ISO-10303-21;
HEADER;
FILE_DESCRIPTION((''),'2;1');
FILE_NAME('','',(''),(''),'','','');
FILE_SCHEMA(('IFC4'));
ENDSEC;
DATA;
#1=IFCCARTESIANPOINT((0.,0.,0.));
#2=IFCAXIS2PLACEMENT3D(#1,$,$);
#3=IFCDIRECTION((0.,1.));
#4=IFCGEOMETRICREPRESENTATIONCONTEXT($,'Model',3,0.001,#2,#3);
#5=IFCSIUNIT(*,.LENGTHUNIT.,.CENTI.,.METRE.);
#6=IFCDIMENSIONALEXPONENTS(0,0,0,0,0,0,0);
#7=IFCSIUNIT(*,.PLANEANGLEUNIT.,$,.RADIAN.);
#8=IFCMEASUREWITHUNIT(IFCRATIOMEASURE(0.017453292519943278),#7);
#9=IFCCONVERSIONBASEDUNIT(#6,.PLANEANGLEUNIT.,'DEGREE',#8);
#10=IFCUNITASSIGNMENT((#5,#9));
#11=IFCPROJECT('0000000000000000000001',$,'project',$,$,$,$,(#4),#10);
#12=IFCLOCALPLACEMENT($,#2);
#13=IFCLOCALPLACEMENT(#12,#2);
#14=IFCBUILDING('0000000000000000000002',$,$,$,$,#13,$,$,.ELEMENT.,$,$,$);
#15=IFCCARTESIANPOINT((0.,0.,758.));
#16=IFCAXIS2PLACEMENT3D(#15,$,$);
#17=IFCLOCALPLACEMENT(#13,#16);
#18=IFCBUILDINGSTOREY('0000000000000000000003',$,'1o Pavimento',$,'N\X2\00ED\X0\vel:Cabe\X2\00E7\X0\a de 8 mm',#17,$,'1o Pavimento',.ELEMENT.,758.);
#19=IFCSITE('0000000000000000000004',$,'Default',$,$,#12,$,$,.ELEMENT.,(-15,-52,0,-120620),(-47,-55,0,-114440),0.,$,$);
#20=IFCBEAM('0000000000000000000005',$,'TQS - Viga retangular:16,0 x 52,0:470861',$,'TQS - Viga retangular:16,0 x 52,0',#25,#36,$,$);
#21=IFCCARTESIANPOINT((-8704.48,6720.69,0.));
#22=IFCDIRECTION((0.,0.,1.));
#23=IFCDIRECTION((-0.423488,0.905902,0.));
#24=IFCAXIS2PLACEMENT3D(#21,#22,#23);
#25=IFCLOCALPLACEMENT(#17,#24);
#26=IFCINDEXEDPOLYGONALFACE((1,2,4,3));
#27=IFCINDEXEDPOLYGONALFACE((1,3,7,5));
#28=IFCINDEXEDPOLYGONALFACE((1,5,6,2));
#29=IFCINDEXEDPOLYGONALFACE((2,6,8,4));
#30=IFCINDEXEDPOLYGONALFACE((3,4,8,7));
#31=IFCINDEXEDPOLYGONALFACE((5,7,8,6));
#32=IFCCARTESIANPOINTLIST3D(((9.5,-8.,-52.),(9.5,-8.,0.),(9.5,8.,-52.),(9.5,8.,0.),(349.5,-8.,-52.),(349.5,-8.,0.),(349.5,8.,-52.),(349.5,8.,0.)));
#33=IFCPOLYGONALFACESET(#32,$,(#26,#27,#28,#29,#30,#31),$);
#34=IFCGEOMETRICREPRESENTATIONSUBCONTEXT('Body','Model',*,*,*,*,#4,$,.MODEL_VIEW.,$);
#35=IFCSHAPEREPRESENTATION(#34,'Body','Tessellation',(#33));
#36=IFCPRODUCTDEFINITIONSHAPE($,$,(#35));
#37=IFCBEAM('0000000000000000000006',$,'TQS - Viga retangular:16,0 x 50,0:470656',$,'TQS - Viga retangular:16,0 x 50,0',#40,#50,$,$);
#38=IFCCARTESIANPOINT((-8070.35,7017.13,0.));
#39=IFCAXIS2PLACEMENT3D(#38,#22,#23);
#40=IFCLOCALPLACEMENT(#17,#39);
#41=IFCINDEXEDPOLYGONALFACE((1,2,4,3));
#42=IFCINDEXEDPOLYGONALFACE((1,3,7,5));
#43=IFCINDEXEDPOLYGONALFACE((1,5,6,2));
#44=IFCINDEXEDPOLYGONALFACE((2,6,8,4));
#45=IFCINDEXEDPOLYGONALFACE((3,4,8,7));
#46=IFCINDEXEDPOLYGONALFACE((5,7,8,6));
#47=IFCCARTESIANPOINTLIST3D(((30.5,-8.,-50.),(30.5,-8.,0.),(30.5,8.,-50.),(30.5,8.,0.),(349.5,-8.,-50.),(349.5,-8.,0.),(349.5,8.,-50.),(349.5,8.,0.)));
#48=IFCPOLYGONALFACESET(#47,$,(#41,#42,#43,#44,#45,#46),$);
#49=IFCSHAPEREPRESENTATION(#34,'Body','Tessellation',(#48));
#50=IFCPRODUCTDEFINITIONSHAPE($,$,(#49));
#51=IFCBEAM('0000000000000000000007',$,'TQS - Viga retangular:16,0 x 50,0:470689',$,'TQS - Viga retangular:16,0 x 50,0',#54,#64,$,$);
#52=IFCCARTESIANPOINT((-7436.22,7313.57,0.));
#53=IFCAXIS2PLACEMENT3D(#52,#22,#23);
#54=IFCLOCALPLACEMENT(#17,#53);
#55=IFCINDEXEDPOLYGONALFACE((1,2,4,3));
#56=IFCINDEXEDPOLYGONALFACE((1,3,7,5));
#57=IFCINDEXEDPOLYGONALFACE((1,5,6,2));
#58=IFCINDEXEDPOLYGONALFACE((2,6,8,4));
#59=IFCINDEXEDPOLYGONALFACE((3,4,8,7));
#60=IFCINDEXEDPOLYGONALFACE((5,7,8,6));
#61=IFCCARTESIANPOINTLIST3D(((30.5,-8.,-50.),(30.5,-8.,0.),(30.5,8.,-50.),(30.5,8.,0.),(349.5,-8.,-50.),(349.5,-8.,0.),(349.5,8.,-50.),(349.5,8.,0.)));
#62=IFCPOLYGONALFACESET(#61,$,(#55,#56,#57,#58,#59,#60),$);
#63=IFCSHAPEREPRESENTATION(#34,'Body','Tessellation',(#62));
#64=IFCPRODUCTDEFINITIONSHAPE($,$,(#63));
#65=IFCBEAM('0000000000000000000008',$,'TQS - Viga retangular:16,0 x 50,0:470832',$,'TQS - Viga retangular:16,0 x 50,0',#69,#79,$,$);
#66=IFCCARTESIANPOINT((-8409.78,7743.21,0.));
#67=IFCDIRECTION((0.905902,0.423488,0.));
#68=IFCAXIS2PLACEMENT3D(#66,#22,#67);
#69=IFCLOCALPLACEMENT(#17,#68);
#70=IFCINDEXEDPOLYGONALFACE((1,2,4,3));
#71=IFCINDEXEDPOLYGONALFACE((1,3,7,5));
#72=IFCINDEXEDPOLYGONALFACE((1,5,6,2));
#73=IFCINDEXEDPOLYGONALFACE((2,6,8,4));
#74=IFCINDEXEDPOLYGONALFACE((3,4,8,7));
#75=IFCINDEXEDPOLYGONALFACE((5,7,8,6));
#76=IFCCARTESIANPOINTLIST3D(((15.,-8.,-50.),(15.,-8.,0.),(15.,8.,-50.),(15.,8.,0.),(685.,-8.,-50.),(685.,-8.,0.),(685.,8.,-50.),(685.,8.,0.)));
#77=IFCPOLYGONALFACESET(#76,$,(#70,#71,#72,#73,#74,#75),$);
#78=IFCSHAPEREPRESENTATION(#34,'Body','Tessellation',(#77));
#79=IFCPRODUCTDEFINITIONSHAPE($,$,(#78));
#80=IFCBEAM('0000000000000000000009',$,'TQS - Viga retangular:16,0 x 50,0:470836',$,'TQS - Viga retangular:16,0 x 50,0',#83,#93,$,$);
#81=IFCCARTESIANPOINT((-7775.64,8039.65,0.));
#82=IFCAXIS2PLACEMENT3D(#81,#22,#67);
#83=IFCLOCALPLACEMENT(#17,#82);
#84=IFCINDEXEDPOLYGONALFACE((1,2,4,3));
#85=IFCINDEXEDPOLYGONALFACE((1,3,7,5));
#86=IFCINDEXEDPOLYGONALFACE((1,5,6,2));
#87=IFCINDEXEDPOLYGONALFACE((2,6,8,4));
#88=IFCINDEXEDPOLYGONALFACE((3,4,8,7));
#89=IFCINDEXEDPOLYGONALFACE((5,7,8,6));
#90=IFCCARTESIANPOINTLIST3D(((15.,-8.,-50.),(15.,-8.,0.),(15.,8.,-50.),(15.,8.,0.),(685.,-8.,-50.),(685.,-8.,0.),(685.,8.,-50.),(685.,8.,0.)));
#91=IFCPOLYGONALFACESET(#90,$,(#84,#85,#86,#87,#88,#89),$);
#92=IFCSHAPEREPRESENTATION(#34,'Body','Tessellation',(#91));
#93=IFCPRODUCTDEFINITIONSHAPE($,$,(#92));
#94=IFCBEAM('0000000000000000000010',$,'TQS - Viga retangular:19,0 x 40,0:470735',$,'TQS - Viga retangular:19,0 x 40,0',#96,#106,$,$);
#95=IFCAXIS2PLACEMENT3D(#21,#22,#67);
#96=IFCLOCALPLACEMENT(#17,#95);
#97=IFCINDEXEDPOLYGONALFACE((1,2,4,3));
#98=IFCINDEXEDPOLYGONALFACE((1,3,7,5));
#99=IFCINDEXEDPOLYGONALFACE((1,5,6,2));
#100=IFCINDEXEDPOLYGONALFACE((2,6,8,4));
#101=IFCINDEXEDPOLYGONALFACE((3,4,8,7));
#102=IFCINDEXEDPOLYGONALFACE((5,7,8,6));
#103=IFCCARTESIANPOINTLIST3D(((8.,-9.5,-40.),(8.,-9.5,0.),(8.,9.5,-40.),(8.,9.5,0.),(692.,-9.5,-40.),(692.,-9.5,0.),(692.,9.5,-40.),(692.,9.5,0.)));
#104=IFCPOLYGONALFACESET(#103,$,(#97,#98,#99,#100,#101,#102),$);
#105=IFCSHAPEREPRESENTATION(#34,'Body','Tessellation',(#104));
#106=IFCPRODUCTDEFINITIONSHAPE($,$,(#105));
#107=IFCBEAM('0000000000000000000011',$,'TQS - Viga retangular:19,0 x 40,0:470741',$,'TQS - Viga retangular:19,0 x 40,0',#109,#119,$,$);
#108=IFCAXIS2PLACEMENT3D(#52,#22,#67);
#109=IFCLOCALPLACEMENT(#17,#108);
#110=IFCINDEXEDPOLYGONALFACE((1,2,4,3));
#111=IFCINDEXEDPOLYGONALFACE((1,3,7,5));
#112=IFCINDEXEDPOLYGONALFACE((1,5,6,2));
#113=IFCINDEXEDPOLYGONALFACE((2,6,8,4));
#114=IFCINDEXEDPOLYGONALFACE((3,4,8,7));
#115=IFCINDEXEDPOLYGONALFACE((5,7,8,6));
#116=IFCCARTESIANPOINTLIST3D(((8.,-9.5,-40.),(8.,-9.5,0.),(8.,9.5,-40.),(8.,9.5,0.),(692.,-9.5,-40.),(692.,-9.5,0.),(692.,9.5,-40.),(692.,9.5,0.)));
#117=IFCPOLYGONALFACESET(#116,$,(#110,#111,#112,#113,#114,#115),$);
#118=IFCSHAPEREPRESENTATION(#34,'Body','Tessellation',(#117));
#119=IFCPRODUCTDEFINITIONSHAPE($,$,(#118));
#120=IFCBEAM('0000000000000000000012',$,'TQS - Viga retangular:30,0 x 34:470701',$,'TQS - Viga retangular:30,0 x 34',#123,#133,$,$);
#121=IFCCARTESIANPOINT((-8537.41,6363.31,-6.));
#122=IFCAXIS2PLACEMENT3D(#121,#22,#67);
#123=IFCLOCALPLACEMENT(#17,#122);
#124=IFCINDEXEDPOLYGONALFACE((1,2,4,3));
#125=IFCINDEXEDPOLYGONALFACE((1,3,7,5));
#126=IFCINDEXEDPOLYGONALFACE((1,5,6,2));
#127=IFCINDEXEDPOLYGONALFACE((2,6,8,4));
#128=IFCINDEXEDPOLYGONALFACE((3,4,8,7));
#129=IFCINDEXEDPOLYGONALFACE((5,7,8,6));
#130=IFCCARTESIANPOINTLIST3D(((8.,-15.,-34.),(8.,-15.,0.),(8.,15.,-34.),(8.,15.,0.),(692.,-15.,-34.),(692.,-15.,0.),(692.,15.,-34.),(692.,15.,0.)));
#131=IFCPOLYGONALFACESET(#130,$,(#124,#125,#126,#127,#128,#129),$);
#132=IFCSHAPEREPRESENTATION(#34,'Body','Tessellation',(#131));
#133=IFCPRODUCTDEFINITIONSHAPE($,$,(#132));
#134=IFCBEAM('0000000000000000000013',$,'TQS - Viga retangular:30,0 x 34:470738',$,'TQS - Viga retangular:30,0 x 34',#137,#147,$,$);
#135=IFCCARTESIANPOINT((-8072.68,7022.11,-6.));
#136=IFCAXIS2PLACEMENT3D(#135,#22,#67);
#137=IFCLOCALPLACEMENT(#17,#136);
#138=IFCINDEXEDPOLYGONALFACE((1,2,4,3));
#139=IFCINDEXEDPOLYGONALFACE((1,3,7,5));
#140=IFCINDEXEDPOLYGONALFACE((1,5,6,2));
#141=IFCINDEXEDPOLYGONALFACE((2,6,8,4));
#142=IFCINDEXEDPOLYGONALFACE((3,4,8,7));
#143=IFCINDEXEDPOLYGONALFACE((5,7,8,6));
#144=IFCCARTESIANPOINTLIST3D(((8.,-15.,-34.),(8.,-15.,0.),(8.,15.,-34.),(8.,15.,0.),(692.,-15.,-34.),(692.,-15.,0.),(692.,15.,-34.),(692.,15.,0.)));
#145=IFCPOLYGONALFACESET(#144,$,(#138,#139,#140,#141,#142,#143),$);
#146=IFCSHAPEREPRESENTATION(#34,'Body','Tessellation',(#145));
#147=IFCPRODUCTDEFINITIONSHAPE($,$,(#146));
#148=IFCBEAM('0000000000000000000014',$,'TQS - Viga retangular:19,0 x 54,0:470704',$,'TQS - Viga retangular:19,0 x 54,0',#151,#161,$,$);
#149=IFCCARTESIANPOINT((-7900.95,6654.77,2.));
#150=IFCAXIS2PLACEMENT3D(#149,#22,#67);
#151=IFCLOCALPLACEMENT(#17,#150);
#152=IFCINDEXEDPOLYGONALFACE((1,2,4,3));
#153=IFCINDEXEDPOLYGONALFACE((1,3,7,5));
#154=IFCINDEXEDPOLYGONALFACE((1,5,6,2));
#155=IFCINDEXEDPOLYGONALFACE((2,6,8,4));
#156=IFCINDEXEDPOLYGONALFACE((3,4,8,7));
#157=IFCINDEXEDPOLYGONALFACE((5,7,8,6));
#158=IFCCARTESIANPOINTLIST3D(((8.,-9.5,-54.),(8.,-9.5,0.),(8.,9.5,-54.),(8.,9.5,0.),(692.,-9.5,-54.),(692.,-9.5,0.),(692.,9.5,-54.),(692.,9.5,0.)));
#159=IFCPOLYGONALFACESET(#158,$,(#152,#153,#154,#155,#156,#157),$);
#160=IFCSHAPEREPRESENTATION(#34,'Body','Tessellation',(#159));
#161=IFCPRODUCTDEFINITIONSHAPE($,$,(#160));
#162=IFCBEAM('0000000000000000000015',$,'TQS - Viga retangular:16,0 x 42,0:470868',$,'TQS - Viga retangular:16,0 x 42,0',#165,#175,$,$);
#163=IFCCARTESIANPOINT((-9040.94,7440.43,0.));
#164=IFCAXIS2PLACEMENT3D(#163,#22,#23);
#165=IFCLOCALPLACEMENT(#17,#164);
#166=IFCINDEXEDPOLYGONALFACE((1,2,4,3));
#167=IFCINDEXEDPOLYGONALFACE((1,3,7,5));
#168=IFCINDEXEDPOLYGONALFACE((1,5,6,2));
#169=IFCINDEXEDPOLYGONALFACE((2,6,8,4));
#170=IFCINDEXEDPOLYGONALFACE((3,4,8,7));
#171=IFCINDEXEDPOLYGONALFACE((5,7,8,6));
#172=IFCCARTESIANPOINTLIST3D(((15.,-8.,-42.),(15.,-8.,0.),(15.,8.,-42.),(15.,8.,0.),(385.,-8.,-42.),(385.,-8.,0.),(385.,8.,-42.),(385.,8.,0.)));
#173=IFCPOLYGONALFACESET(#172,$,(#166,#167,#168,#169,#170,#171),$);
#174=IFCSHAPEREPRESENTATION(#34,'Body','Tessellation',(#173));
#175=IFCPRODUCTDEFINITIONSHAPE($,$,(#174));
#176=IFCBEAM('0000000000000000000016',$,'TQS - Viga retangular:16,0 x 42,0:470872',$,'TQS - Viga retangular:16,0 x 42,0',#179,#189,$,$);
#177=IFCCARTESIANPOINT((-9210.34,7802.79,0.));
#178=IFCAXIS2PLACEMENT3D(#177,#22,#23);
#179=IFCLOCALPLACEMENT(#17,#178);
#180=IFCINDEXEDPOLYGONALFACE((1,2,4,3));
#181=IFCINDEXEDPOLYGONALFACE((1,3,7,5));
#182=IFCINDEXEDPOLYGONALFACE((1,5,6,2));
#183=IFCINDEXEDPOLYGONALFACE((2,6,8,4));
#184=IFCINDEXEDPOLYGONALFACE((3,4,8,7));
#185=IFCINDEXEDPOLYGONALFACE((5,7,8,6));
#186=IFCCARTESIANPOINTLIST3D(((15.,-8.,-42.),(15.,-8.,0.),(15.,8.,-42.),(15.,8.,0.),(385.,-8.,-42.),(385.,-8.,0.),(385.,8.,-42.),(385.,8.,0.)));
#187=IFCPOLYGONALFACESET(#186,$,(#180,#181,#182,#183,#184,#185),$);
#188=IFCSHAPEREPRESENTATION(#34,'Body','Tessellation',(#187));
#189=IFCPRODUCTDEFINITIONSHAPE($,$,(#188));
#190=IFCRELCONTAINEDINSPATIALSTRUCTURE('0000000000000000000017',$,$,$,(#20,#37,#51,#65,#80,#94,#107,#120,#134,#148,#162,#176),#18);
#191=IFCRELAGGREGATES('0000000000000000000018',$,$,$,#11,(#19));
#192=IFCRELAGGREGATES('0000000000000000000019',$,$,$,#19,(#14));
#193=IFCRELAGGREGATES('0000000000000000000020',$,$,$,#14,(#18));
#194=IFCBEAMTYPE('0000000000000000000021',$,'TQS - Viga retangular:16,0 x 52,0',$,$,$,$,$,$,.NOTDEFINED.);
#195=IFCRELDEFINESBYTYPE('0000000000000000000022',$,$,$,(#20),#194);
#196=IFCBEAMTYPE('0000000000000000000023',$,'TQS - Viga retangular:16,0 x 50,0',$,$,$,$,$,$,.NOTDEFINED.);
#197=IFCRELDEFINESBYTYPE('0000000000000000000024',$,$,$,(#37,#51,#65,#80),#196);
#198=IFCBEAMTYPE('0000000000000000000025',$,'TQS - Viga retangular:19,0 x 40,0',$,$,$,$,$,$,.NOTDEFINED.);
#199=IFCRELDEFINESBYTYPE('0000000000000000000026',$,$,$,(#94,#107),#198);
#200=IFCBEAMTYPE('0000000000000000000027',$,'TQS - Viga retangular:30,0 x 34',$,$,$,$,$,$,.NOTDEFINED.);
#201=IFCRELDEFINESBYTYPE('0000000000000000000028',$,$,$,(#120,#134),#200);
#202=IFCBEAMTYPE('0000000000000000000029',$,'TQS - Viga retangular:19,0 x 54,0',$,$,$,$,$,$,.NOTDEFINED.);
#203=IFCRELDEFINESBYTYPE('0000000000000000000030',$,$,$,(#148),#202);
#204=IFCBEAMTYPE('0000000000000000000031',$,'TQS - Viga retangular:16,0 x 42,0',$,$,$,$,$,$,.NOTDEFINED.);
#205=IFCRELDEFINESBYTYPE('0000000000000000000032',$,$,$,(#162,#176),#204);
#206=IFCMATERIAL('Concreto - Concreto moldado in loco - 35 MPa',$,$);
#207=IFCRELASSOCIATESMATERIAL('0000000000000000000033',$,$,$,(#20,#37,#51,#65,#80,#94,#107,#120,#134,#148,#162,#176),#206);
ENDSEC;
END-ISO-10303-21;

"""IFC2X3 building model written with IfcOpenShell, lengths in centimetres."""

from ifc_helpers import new_model, entity, si_unit, converted_unit, direction, frame, frame_2d, origin, origin_2d_with_axis, place, context, subcontext, project, spatial, rectangle, extrude, material, type_object, element, save


model = new_model("IFC2X3")

# Units and contexts
model_context = context("Model", 3, precision=0.001, world=origin(), true_north=direction((0.0, 1.0)))
body_context = subcontext(model_context, "Body", "Model", "MODEL_VIEW")
ifc_project = project(units=[si_unit("LENGTHUNIT", "METRE", prefix="CENTI"), converted_unit("PLANEANGLEUNIT", "DEGREE", entity("IfcRatioMeasure", 0.017453292519943278), si_unit("PLANEANGLEUNIT", "RADIAN"), dimensions=[0, 0, 0, 0, 0, 0, 0])], contexts=[model_context])

# Site, building, storey
site_placement = place(None, origin())
site = spatial("IfcSite", under=ifc_project, at=site_placement, Name="Default", CompositionType="ELEMENT", RefLatitude=(-15, -52, 0, -120620), RefLongitude=(-47, -55, 0, -114440), RefElevation=0.0)
building_placement = place(site_placement, origin())
building = spatial("IfcBuilding", under=site, at=building_placement, CompositionType="ELEMENT")
storey_placement = place(building_placement, frame((0.0, 0.0, 758.0)))
storey = spatial("IfcBuildingStorey", under=building, at=storey_placement, Name="1o Pavimento", ObjectType="Nível:Cabeça de 8 mm", LongName="1o Pavimento", CompositionType="ELEMENT", Elevation=758.0)

# Beams
ifc_material_1 = material(Name="Concreto - Concreto moldado in loco - 35 MPa")
beam_type_1 = type_object("IfcBeamType", Name="TQS - Viga retangular:16,0 x 52,0", PredefinedType="NOTDEFINED")
beam_1_placement = place(storey_placement, frame((-8704.48, 6720.69, 0.0), z_axis=(0.0, 0.0, 1.0), x_axis=(-0.423488, 0.905902, 0.0)))
element("IfcBeam", 1, at=beam_1_placement, inside=storey, type_object=beam_type_1, material=ifc_material_1, Name="TQS - Viga retangular:16,0 x 52,0:470861", ObjectType="TQS - Viga retangular:16,0 x 52,0", context=body_context, shape_type="SweptSolid", body=[
    extrude(rectangle(XDim=52.0, YDim=16.0, at=frame_2d((0.0, 0.0), x_axis=(1.0, 0.0))), frame((9.5, 0.0, -26.0), z_axis=(1.0, 0.0, 0.0), x_axis=(0.0, 0.0, -1.0)), (0.0, 0.0, 1.0), 340.0),
])
beam_type_2 = type_object("IfcBeamType", Name="TQS - Viga retangular:16,0 x 50,0", PredefinedType="NOTDEFINED")
beam_2_placement = place(storey_placement, frame((-8070.35, 7017.13, 0.0), z_axis=(0.0, 0.0, 1.0), x_axis=(-0.423488, 0.905902, 0.0)))
element("IfcBeam", 2, at=beam_2_placement, inside=storey, type_object=beam_type_2, material=ifc_material_1, Name="TQS - Viga retangular:16,0 x 50,0:470656", ObjectType="TQS - Viga retangular:16,0 x 50,0", context=body_context, shape_type="SweptSolid", body=[
    extrude(rectangle(XDim=50.0, YDim=16.0, at=frame_2d((0.0, 0.0), x_axis=(1.0, 0.0))), frame((30.5, 0.0, -25.0), z_axis=(1.0, 0.0, 0.0), x_axis=(0.0, 0.0, -1.0)), (0.0, 0.0, 1.0), 319.0),
])
beam_3_placement = place(storey_placement, frame((-7436.22, 7313.57, 0.0), z_axis=(0.0, 0.0, 1.0), x_axis=(-0.423488, 0.905902, 0.0)))
element("IfcBeam", 3, at=beam_3_placement, inside=storey, type_object=beam_type_2, material=ifc_material_1, Name="TQS - Viga retangular:16,0 x 50,0:470689", ObjectType="TQS - Viga retangular:16,0 x 50,0", context=body_context, shape_type="SweptSolid", body=[
    extrude(rectangle(XDim=50.0, YDim=16.0, at=frame_2d((0.0, 0.0), x_axis=(1.0, 0.0))), frame((30.5, 0.0, -25.0), z_axis=(1.0, 0.0, 0.0), x_axis=(0.0, 0.0, -1.0)), (0.0, 0.0, 1.0), 319.0),
])
beam_4_placement = place(storey_placement, frame((-8409.78, 7743.21, 0.0), z_axis=(0.0, 0.0, 1.0), x_axis=(0.905902, 0.423488, 0.0)))
element("IfcBeam", 4, at=beam_4_placement, inside=storey, type_object=beam_type_2, material=ifc_material_1, Name="TQS - Viga retangular:16,0 x 50,0:470832", ObjectType="TQS - Viga retangular:16,0 x 50,0", context=body_context, shape_type="SweptSolid", body=[
    extrude(rectangle(XDim=50.0, YDim=16.0, at=frame_2d((0.0, 0.0), x_axis=(1.0, 0.0))), frame((15.0, 0.0, -25.0), z_axis=(1.0, 0.0, 0.0), x_axis=(0.0, 0.0, -1.0)), (0.0, 0.0, 1.0), 670.0),
])
beam_5_placement = place(storey_placement, frame((-7775.64, 8039.65, 0.0), z_axis=(0.0, 0.0, 1.0), x_axis=(0.905902, 0.423488, 0.0)))
element("IfcBeam", 5, at=beam_5_placement, inside=storey, type_object=beam_type_2, material=ifc_material_1, Name="TQS - Viga retangular:16,0 x 50,0:470836", ObjectType="TQS - Viga retangular:16,0 x 50,0", context=body_context, shape_type="SweptSolid", body=[
    extrude(rectangle(XDim=50.0, YDim=16.0, at=frame_2d((0.0, 0.0), x_axis=(1.0, 0.0))), frame((15.0, 0.0, -25.0), z_axis=(1.0, 0.0, 0.0), x_axis=(0.0, 0.0, -1.0)), (0.0, 0.0, 1.0), 670.0),
])
beam_type_3 = type_object("IfcBeamType", Name="TQS - Viga retangular:19,0 x 40,0", PredefinedType="NOTDEFINED")
beam_6_placement = place(storey_placement, frame((-8704.48, 6720.69, 0.0), z_axis=(0.0, 0.0, 1.0), x_axis=(0.905902, 0.423488, 0.0)))
element("IfcBeam", 6, at=beam_6_placement, inside=storey, type_object=beam_type_3, material=ifc_material_1, Name="TQS - Viga retangular:19,0 x 40,0:470735", ObjectType="TQS - Viga retangular:19,0 x 40,0", context=body_context, shape_type="SweptSolid", body=[
    extrude(rectangle(XDim=40.0, YDim=19.0, at=frame_2d((0.0, 0.0), x_axis=(1.0, 0.0))), frame((8.0, 0.0, -20.0), z_axis=(1.0, 0.0, 0.0), x_axis=(0.0, 0.0, -1.0)), (0.0, 0.0, 1.0), 684.0),
])
beam_7_placement = place(storey_placement, frame((-7436.22, 7313.57, 0.0), z_axis=(0.0, 0.0, 1.0), x_axis=(0.905902, 0.423488, 0.0)))
element("IfcBeam", 7, at=beam_7_placement, inside=storey, type_object=beam_type_3, material=ifc_material_1, Name="TQS - Viga retangular:19,0 x 40,0:470741", ObjectType="TQS - Viga retangular:19,0 x 40,0", context=body_context, shape_type="SweptSolid", body=[
    extrude(rectangle(XDim=40.0, YDim=19.0, at=origin_2d_with_axis()), frame((8.0, 0.0, -20.0), z_axis=(1.0, 0.0, 0.0), x_axis=(0.0, 0.0, -1.0)), (0.0, 0.0, 1.0), 684.0),
])
beam_type_4 = type_object("IfcBeamType", Name="TQS - Viga retangular:30,0 x 34", PredefinedType="NOTDEFINED")
beam_8_placement = place(storey_placement, frame((-8537.41, 6363.31, -6.0), z_axis=(0.0, 0.0, 1.0), x_axis=(0.905902, 0.423488, 0.0)))
element("IfcBeam", 8, at=beam_8_placement, inside=storey, type_object=beam_type_4, material=ifc_material_1, Name="TQS - Viga retangular:30,0 x 34:470701", ObjectType="TQS - Viga retangular:30,0 x 34", context=body_context, shape_type="SweptSolid", body=[
    extrude(rectangle(XDim=34.0, YDim=30.0, at=frame_2d((0.0, 0.0), x_axis=(1.0, 0.0))), frame((8.0, 0.0, -17.0), z_axis=(1.0, 0.0, 0.0), x_axis=(0.0, 0.0, -1.0)), (0.0, 0.0, 1.0), 684.0),
])
beam_9_placement = place(storey_placement, frame((-8072.68, 7022.11, -6.0), z_axis=(0.0, 0.0, 1.0), x_axis=(0.905902, 0.423488, 0.0)))
element("IfcBeam", 9, at=beam_9_placement, inside=storey, type_object=beam_type_4, material=ifc_material_1, Name="TQS - Viga retangular:30,0 x 34:470738", ObjectType="TQS - Viga retangular:30,0 x 34", context=body_context, shape_type="SweptSolid", body=[
    extrude(rectangle(XDim=34.0, YDim=30.0, at=frame_2d((0.0, 0.0), x_axis=(1.0, 0.0))), frame((8.0, 0.0, -17.0), z_axis=(1.0, 0.0, 0.0), x_axis=(0.0, 0.0, -1.0)), (0.0, 0.0, 1.0), 684.0),
])
beam_type_5 = type_object("IfcBeamType", Name="TQS - Viga retangular:19,0 x 54,0", PredefinedType="NOTDEFINED")
beam_10_placement = place(storey_placement, frame((-7900.95, 6654.77, 2.0), z_axis=(0.0, 0.0, 1.0), x_axis=(0.905902, 0.423488, 0.0)))
element("IfcBeam", 10, at=beam_10_placement, inside=storey, type_object=beam_type_5, material=ifc_material_1, Name="TQS - Viga retangular:19,0 x 54,0:470704", ObjectType="TQS - Viga retangular:19,0 x 54,0", context=body_context, shape_type="SweptSolid", body=[
    extrude(rectangle(XDim=54.0, YDim=19.0, at=frame_2d((0.0, 0.0), x_axis=(1.0, 0.0))), frame((8.0, 0.0, -27.0), z_axis=(1.0, 0.0, 0.0), x_axis=(0.0, 0.0, -1.0)), (0.0, 0.0, 1.0), 684.0),
])
beam_type_6 = type_object("IfcBeamType", Name="TQS - Viga retangular:16,0 x 42,0", PredefinedType="NOTDEFINED")
beam_11_placement = place(storey_placement, frame((-9040.94, 7440.43, 0.0), z_axis=(0.0, 0.0, 1.0), x_axis=(-0.423488, 0.905902, 0.0)))
element("IfcBeam", 11, at=beam_11_placement, inside=storey, type_object=beam_type_6, material=ifc_material_1, Name="TQS - Viga retangular:16,0 x 42,0:470868", ObjectType="TQS - Viga retangular:16,0 x 42,0", context=body_context, shape_type="SweptSolid", body=[
    extrude(rectangle(XDim=42.0, YDim=16.0, at=frame_2d((0.0, 0.0), x_axis=(1.0, 0.0))), frame((15.0, 0.0, -21.0), z_axis=(1.0, 0.0, 0.0), x_axis=(0.0, 0.0, -1.0)), (0.0, 0.0, 1.0), 370.0),
])
beam_12_placement = place(storey_placement, frame((-9210.34, 7802.79, 0.0), z_axis=(0.0, 0.0, 1.0), x_axis=(-0.423488, 0.905902, 0.0)))
element("IfcBeam", 12, at=beam_12_placement, inside=storey, type_object=beam_type_6, material=ifc_material_1, Name="TQS - Viga retangular:16,0 x 42,0:470872", ObjectType="TQS - Viga retangular:16,0 x 42,0", context=body_context, shape_type="SweptSolid", body=[
    extrude(rectangle(XDim=42.0, YDim=16.0, at=frame_2d((0.0, 0.0), x_axis=(1.0, 0.0))), frame((15.0, 0.0, -21.0), z_axis=(1.0, 0.0, 0.0), x_axis=(0.0, 0.0, -1.0)), (0.0, 0.0, 1.0), 370.0),
])

save(model, "model.ifc")
